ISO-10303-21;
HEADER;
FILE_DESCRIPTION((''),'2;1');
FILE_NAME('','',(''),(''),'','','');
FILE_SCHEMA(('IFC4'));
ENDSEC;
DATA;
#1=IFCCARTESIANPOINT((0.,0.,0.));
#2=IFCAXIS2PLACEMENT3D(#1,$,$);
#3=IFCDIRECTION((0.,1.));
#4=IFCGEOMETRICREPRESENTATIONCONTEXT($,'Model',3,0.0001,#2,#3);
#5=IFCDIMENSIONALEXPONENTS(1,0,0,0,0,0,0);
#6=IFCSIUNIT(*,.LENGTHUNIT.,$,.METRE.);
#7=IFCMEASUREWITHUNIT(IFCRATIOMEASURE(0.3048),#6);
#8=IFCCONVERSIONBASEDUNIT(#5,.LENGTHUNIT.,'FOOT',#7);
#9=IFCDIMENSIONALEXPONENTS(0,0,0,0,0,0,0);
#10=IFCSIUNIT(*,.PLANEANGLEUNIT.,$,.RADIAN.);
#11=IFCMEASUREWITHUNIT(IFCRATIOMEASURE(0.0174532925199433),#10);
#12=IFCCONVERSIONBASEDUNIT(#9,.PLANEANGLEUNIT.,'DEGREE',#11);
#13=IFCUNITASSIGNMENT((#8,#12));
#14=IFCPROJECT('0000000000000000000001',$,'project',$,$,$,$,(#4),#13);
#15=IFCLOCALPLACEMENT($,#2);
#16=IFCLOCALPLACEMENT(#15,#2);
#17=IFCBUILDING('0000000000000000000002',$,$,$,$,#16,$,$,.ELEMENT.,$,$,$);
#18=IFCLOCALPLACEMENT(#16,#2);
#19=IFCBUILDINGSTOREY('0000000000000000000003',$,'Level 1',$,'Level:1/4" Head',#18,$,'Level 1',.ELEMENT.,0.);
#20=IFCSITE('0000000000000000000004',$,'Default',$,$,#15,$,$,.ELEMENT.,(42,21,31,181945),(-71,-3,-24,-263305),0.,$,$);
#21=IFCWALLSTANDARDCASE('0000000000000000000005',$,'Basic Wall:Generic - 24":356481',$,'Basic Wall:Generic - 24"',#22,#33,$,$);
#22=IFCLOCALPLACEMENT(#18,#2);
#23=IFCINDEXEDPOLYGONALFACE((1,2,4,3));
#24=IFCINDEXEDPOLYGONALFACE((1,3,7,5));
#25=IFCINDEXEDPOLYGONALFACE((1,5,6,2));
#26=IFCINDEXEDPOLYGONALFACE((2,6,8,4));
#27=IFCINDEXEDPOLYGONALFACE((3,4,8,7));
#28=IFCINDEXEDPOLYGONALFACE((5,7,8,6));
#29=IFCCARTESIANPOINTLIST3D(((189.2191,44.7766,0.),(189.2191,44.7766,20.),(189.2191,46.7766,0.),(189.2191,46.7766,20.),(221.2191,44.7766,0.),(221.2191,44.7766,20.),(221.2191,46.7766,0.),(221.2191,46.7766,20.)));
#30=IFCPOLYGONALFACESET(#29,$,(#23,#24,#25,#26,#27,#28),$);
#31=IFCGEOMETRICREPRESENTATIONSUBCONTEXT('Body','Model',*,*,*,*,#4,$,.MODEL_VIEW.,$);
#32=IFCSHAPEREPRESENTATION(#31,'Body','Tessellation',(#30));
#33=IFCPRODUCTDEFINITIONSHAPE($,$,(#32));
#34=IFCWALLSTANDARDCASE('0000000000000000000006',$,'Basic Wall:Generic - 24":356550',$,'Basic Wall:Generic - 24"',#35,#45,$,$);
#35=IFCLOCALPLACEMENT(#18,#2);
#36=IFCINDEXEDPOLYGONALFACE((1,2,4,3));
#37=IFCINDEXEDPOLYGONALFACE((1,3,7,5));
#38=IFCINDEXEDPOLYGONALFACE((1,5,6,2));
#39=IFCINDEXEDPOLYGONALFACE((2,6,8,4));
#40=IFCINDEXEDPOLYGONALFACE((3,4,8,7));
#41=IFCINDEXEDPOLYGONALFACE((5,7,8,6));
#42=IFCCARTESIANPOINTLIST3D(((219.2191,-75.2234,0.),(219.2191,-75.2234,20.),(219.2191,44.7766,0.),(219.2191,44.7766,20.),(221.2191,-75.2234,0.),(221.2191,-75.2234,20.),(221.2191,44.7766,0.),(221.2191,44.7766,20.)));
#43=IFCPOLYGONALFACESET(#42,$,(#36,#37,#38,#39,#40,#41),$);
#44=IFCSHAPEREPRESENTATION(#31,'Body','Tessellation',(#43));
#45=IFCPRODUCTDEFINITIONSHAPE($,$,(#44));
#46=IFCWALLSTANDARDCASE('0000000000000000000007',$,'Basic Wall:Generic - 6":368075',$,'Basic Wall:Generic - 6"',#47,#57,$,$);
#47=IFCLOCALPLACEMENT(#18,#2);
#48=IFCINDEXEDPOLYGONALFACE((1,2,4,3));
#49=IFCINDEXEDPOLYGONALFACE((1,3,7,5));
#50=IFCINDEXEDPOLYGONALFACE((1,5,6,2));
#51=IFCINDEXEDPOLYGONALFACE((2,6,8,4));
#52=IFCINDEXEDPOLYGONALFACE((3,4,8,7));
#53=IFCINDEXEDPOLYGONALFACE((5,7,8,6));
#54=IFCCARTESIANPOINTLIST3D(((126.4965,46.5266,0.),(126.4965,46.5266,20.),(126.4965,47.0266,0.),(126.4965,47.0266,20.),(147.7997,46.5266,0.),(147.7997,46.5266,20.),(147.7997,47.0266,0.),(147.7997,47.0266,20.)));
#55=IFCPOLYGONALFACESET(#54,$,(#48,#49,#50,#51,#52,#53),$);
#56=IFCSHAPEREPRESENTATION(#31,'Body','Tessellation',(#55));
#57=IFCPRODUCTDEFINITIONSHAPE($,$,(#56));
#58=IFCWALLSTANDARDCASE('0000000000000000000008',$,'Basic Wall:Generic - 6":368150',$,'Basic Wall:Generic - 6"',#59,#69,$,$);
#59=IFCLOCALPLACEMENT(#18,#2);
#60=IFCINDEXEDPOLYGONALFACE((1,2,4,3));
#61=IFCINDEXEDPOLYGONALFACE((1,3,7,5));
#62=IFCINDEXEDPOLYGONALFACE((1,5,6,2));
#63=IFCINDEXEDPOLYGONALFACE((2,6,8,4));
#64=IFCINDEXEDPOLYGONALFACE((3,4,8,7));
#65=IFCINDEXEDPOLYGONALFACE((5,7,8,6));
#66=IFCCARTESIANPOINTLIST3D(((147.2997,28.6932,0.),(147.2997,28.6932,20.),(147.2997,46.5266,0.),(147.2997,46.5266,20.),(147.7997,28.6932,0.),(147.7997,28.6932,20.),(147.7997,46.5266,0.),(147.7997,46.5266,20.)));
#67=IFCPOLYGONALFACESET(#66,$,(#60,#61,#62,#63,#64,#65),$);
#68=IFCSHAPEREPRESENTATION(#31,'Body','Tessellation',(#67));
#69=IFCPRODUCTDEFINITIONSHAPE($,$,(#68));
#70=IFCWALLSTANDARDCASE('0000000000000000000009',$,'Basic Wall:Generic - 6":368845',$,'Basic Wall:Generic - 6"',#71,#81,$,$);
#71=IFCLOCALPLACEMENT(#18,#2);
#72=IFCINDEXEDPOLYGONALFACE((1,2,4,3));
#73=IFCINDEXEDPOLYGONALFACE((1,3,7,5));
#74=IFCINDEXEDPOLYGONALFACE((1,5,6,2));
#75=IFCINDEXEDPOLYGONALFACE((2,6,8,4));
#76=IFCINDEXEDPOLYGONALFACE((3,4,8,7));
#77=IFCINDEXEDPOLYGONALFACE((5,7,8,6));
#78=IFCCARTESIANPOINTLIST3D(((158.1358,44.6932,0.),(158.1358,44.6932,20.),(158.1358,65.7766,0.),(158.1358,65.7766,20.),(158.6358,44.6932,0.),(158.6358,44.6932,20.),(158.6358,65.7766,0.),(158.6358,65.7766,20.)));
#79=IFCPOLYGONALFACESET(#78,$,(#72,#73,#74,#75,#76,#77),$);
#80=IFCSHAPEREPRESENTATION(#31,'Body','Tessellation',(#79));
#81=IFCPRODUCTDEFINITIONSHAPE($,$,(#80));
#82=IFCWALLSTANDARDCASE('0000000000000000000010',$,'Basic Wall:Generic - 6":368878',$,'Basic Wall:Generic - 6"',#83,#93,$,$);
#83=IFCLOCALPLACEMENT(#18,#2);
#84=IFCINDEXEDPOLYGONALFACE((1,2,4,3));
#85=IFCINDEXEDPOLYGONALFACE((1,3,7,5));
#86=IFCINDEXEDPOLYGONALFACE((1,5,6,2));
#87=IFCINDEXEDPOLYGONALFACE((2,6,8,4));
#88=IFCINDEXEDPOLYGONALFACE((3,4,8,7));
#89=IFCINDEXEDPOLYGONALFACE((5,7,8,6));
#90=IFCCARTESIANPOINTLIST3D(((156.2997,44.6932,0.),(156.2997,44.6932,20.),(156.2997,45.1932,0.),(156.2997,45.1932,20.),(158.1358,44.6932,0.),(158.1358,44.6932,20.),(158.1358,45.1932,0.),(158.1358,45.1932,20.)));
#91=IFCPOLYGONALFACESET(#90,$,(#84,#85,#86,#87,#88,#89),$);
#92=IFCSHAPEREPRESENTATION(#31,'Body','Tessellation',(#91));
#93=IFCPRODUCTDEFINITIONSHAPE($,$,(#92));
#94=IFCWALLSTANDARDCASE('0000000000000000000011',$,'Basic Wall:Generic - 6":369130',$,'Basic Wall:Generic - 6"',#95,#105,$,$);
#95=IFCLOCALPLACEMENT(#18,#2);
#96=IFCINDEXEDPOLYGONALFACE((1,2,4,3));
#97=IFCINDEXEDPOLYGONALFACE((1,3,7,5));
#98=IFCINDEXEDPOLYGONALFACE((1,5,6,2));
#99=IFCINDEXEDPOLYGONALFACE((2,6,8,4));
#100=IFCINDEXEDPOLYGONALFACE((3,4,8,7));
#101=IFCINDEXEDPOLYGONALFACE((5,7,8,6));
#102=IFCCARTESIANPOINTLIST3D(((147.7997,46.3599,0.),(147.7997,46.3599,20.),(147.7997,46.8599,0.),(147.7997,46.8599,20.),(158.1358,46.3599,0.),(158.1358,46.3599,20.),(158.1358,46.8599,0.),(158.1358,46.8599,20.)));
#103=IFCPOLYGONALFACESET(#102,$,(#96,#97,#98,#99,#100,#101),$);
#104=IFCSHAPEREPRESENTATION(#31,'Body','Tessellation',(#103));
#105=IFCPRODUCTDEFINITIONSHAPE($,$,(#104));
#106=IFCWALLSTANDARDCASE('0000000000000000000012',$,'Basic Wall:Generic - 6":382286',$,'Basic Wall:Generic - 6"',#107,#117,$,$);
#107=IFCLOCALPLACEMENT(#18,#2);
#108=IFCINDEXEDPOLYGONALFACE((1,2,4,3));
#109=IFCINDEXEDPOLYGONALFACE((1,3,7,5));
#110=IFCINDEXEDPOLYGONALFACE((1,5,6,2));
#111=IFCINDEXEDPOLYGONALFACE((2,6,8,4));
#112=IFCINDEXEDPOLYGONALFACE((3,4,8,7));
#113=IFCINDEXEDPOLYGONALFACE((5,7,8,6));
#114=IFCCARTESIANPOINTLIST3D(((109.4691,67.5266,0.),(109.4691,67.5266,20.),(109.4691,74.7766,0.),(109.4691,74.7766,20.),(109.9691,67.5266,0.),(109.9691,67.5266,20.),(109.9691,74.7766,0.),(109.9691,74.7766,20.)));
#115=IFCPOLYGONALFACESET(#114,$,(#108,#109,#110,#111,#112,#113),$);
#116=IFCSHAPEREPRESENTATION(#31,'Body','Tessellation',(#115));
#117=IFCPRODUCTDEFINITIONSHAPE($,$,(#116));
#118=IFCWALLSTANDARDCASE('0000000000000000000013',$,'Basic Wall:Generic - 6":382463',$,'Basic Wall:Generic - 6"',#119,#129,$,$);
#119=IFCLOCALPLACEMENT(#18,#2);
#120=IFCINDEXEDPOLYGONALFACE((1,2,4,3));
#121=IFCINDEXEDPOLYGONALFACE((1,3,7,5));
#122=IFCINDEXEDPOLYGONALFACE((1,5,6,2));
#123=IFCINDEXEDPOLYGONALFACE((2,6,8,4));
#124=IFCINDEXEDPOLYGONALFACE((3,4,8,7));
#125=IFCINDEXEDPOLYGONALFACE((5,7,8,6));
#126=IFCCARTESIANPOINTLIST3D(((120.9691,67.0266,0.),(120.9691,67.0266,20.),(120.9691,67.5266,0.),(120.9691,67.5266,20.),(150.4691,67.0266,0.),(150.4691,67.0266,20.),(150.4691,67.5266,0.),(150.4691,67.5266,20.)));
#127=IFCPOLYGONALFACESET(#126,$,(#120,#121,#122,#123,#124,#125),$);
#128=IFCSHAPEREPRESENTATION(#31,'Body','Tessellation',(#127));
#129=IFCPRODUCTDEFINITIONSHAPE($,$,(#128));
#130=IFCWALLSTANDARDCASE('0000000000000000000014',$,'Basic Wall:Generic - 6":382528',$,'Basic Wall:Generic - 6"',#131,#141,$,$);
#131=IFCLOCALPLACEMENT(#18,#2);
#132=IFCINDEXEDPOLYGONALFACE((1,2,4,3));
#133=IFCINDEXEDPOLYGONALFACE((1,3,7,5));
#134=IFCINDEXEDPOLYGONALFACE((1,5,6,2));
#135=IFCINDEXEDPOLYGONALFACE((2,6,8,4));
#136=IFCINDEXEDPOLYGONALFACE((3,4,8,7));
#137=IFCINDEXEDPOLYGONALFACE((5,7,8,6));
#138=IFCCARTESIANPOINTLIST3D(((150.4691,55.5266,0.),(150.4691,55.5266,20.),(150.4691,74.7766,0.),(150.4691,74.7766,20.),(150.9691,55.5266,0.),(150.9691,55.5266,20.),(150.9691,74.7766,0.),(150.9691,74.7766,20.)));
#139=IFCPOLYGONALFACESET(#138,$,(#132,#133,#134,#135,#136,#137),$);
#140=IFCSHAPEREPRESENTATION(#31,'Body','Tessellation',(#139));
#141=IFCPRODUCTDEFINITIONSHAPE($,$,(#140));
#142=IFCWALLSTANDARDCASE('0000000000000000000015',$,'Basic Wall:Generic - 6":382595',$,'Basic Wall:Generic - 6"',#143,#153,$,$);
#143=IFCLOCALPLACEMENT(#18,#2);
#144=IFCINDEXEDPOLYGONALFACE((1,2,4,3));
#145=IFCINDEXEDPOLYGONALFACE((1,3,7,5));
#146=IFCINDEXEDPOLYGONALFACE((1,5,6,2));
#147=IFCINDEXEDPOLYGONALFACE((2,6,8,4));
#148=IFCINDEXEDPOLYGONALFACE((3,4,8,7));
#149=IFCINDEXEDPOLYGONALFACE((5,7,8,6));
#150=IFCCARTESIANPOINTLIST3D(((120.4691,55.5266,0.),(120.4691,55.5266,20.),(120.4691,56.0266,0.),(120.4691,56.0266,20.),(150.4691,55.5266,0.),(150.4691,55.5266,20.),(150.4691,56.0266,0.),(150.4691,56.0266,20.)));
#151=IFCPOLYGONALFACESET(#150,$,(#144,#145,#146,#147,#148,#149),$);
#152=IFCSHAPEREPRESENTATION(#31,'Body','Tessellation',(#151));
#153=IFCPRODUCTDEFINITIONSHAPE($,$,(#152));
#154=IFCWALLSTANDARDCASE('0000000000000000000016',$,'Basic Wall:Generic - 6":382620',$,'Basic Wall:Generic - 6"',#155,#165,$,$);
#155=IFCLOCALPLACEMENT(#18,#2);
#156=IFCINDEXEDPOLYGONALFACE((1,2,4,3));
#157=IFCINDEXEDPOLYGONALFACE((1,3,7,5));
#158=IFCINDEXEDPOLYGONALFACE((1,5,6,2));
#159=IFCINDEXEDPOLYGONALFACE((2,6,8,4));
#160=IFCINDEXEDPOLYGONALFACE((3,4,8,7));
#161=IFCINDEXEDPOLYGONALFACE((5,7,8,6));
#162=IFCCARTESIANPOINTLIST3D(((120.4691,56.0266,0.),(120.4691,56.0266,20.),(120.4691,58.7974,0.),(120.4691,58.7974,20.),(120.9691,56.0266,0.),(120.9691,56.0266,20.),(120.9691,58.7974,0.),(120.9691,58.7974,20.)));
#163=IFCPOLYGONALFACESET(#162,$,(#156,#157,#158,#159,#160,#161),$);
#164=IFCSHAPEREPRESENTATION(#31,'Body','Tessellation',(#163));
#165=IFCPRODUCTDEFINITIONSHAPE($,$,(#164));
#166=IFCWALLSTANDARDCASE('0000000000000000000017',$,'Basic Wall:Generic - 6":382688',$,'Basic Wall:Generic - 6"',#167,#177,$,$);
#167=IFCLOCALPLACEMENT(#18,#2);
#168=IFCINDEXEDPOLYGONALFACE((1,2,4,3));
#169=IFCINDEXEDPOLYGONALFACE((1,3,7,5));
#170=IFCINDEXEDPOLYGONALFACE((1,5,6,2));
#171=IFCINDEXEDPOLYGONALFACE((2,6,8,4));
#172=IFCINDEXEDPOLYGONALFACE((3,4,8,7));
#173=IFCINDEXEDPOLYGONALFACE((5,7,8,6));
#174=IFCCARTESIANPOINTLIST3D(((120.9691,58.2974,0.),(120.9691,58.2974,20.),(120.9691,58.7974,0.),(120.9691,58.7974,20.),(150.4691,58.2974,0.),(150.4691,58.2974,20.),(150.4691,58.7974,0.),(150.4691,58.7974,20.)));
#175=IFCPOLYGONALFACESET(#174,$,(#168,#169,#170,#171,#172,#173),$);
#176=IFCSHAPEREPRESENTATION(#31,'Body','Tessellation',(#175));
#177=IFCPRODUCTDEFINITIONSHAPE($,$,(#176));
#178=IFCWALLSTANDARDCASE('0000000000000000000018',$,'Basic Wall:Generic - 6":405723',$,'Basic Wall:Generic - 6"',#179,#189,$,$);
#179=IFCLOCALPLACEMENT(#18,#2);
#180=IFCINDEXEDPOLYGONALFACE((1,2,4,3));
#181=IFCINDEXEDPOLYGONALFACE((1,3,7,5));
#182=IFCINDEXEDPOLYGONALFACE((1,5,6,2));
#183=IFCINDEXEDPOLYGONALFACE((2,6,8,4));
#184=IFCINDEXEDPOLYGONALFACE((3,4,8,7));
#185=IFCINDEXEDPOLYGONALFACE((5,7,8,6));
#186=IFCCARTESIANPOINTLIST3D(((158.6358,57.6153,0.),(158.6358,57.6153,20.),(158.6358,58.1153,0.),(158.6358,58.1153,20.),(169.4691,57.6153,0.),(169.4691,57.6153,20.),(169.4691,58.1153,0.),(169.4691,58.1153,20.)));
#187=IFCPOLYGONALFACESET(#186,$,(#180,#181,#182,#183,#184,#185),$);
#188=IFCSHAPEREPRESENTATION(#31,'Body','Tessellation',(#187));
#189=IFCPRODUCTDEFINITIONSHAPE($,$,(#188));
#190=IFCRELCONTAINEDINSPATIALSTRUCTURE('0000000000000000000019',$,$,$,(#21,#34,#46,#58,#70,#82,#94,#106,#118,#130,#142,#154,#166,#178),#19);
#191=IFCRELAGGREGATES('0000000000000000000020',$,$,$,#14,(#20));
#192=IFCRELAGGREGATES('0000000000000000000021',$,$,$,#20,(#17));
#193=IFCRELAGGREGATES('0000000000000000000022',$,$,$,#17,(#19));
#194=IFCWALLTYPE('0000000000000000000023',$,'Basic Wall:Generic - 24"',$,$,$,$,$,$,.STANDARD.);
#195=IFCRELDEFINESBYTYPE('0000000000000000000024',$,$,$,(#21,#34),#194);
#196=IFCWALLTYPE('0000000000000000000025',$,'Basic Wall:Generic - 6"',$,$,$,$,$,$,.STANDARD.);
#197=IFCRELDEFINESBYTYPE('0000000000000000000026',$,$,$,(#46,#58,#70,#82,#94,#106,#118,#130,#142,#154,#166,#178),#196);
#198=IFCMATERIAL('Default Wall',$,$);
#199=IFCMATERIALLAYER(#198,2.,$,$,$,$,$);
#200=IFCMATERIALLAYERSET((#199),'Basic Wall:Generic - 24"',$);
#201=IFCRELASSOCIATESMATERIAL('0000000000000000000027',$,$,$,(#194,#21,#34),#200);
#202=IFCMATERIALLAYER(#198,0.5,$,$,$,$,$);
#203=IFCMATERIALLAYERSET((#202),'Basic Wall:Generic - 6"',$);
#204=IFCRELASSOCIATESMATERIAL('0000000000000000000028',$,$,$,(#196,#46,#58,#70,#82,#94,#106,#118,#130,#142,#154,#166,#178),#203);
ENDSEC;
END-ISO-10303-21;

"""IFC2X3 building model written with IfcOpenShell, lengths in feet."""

from ifc_helpers import new_model, entity, si_unit, converted_unit, direction, frame, frame_2d, origin, place, context, subcontext, project, spatial, rectangle, extrude, material, layer, layer_set, layer_usage, type_object, element, save


model = new_model("IFC2X3")

# Units and contexts
model_context = context("Model", 3, precision=0.0001, world=origin(), true_north=direction((0.0, 1.0)))
body_context = subcontext(model_context, "Body", "Model", "MODEL_VIEW")
ifc_project = project(units=[converted_unit("LENGTHUNIT", "FOOT", entity("IfcRatioMeasure", 0.3048), si_unit("LENGTHUNIT", "METRE"), dimensions=[1, 0, 0, 0, 0, 0, 0]), converted_unit("PLANEANGLEUNIT", "DEGREE", entity("IfcRatioMeasure", 0.0174532925199433), si_unit("PLANEANGLEUNIT", "RADIAN"), dimensions=[0, 0, 0, 0, 0, 0, 0])], contexts=[model_context])

# Site, building, storey
site_placement = place(None, origin())
site = spatial("IfcSite", under=ifc_project, at=site_placement, Name="Default", CompositionType="ELEMENT", RefLatitude=(42, 21, 31, 181945), RefLongitude=(-71, -3, -24, -263305), RefElevation=0.0)
building_placement = place(site_placement, origin())
building = spatial("IfcBuilding", under=site, at=building_placement, CompositionType="ELEMENT")
storey_placement = place(building_placement, origin())
storey = spatial("IfcBuildingStorey", under=building, at=storey_placement, Name="Level 1", ObjectType="Level:1/4\" Head", LongName="Level 1", CompositionType="ELEMENT", Elevation=0.0)

# Walls
ifc_material = material(Name="Default Wall")
ifc_layer_1 = layer(ifc_material, 2.0)
ifc_layer_set_1 = layer_set([ifc_layer_1], Name="Basic Wall:Generic - 24\"")
ifc_layer_usage_1 = layer_usage(ifc_layer_set_1, "AXIS2", "NEGATIVE", 1.0)
wall_type_1 = type_object("IfcWallType", Name="Basic Wall:Generic - 24\"", PredefinedType="STANDARD", material=ifc_layer_set_1)
wall_1_placement = place(storey_placement, frame((189.2191, 45.7766, 0.0)))
element("IfcWallStandardCase", 1, at=wall_1_placement, inside=storey, type_object=wall_type_1, material=ifc_layer_usage_1, Name="Basic Wall:Generic - 24\":356481", ObjectType="Basic Wall:Generic - 24\"", context=body_context, shape_type="SweptSolid", body=[
    extrude(rectangle(XDim=32.0, YDim=2.0, at=frame_2d((16.0, 0.0), x_axis=(-1.0, 0.0))), origin(), (0.0, 0.0, 1.0), 20.0),
])
ifc_layer_usage_2 = layer_usage(ifc_layer_set_1, "AXIS2", "NEGATIVE", 1.0)
wall_2_placement = place(storey_placement, frame((220.2191, 44.7766, 0.0), z_axis=(0.0, 0.0, 1.0), x_axis=(0.0, -1.0, 0.0)))
element("IfcWallStandardCase", 2, at=wall_2_placement, inside=storey, type_object=wall_type_1, material=ifc_layer_usage_2, Name="Basic Wall:Generic - 24\":356550", ObjectType="Basic Wall:Generic - 24\"", context=body_context, shape_type="SweptSolid", body=[
    extrude(rectangle(XDim=120.0, YDim=2.0, at=frame_2d((60.0, 0.0), x_axis=(-1.0, 0.0))), origin(), (0.0, 0.0, 1.0), 20.0),
])
ifc_layer_2 = layer(ifc_material, 0.5)
ifc_layer_set_2 = layer_set([ifc_layer_2], Name="Basic Wall:Generic - 6\"")
ifc_layer_usage_3 = layer_usage(ifc_layer_set_2, "AXIS2", "NEGATIVE", 0.25)
wall_type_2 = type_object("IfcWallType", Name="Basic Wall:Generic - 6\"", PredefinedType="STANDARD", material=ifc_layer_set_2)
wall_3_placement = place(storey_placement, frame((126.4965, 46.7766, 0.0)))
element("IfcWallStandardCase", 3, at=wall_3_placement, inside=storey, type_object=wall_type_2, material=ifc_layer_usage_3, Name="Basic Wall:Generic - 6\":368075", ObjectType="Basic Wall:Generic - 6\"", context=body_context, shape_type="SweptSolid", body=[
    extrude(rectangle(XDim=21.3031, YDim=0.5, at=frame_2d((10.6516, 0.0), x_axis=(-1.0, 0.0))), origin(), (0.0, 0.0, 1.0), 20.0),
])
ifc_layer_usage_4 = layer_usage(ifc_layer_set_2, "AXIS2", "NEGATIVE", 0.25)
wall_4_placement = place(storey_placement, frame((147.5497, 46.5266, 0.0), z_axis=(0.0, 0.0, 1.0), x_axis=(0.0, -1.0, 0.0)))
element("IfcWallStandardCase", 4, at=wall_4_placement, inside=storey, type_object=wall_type_2, material=ifc_layer_usage_4, Name="Basic Wall:Generic - 6\":368150", ObjectType="Basic Wall:Generic - 6\"", context=body_context, shape_type="SweptSolid", body=[
    extrude(rectangle(XDim=17.8333, YDim=0.5, at=frame_2d((8.9167, 0.0), x_axis=(-1.0, 0.0))), origin(), (0.0, 0.0, 1.0), 20.0),
])
ifc_layer_usage_5 = layer_usage(ifc_layer_set_2, "AXIS2", "NEGATIVE", 0.25)
wall_5_placement = place(storey_placement, frame((158.3858, 65.7766, 0.0), z_axis=(0.0, 0.0, 1.0), x_axis=(0.0, -1.0, 0.0)))
element("IfcWallStandardCase", 5, at=wall_5_placement, inside=storey, type_object=wall_type_2, material=ifc_layer_usage_5, Name="Basic Wall:Generic - 6\":368845", ObjectType="Basic Wall:Generic - 6\"", context=body_context, shape_type="SweptSolid", body=[
    extrude(rectangle(XDim=21.0833, YDim=0.5, at=frame_2d((10.5417, 0.0), x_axis=(-1.0, 0.0))), origin(), (0.0, 0.0, 1.0), 20.0),
])
ifc_layer_usage_6 = layer_usage(ifc_layer_set_2, "AXIS2", "NEGATIVE", 0.25)
wall_6_placement = place(storey_placement, frame((158.1358, 44.9432, 0.0), z_axis=(0.0, 0.0, 1.0), x_axis=(-1.0, 0.0, 0.0)))
element("IfcWallStandardCase", 6, at=wall_6_placement, inside=storey, type_object=wall_type_2, material=ifc_layer_usage_6, Name="Basic Wall:Generic - 6\":368878", ObjectType="Basic Wall:Generic - 6\"", context=body_context, shape_type="SweptSolid", body=[
    extrude(rectangle(XDim=1.8361, YDim=0.5, at=frame_2d((0.9181, 0.0), x_axis=(-1.0, 0.0))), origin(), (0.0, 0.0, 1.0), 20.0),
])
ifc_layer_usage_7 = layer_usage(ifc_layer_set_2, "AXIS2", "NEGATIVE", 0.25)
wall_7_placement = place(storey_placement, frame((158.1358, 46.6099, 0.0), z_axis=(0.0, 0.0, 1.0), x_axis=(-1.0, 0.0, 0.0)))
element("IfcWallStandardCase", 7, at=wall_7_placement, inside=storey, type_object=wall_type_2, material=ifc_layer_usage_7, Name="Basic Wall:Generic - 6\":369130", ObjectType="Basic Wall:Generic - 6\"", context=body_context, shape_type="SweptSolid", body=[
    extrude(rectangle(XDim=10.3361, YDim=0.5, at=frame_2d((5.1681, 0.0), x_axis=(-1.0, 0.0))), origin(), (0.0, 0.0, 1.0), 20.0),
])
ifc_layer_usage_8 = layer_usage(ifc_layer_set_2, "AXIS2", "NEGATIVE", 0.25)
wall_8_placement = place(storey_placement, frame((109.7191, 67.5266, 0.0), z_axis=(0.0, 0.0, 1.0), x_axis=(0.0, 1.0, 0.0)))
element("IfcWallStandardCase", 8, at=wall_8_placement, inside=storey, type_object=wall_type_2, material=ifc_layer_usage_8, Name="Basic Wall:Generic - 6\":382286", ObjectType="Basic Wall:Generic - 6\"", context=body_context, shape_type="SweptSolid", body=[
    extrude(rectangle(XDim=7.25, YDim=0.5, at=frame_2d((3.625, 0.0), x_axis=(-1.0, 0.0))), origin(), (0.0, 0.0, 1.0), 20.0),
])
ifc_layer_usage_9 = layer_usage(ifc_layer_set_2, "AXIS2", "NEGATIVE", 0.25)
wall_9_placement = place(storey_placement, frame((120.9691, 67.2766, 0.0)))
element("IfcWallStandardCase", 9, at=wall_9_placement, inside=storey, type_object=wall_type_2, material=ifc_layer_usage_9, Name="Basic Wall:Generic - 6\":382463", ObjectType="Basic Wall:Generic - 6\"", context=body_context, shape_type="SweptSolid", body=[
    extrude(rectangle(XDim=29.5, YDim=0.5, at=frame_2d((14.75, 0.0), x_axis=(-1.0, 0.0))), origin(), (0.0, 0.0, 1.0), 20.0),
])
ifc_layer_usage_10 = layer_usage(ifc_layer_set_2, "AXIS2", "NEGATIVE", 0.25)
wall_10_placement = place(storey_placement, frame((150.7191, 74.7766, 0.0), z_axis=(0.0, 0.0, 1.0), x_axis=(0.0, -1.0, 0.0)))
element("IfcWallStandardCase", 10, at=wall_10_placement, inside=storey, type_object=wall_type_2, material=ifc_layer_usage_10, Name="Basic Wall:Generic - 6\":382528", ObjectType="Basic Wall:Generic - 6\"", context=body_context, shape_type="SweptSolid", body=[
    extrude(rectangle(XDim=19.25, YDim=0.5, at=frame_2d((9.625, 0.0), x_axis=(-1.0, 0.0))), origin(), (0.0, 0.0, 1.0), 20.0),
])
ifc_layer_usage_11 = layer_usage(ifc_layer_set_2, "AXIS2", "NEGATIVE", 0.25)
wall_11_placement = place(storey_placement, frame((150.4691, 55.7766, 0.0), z_axis=(0.0, 0.0, 1.0), x_axis=(-1.0, 0.0, 0.0)))
element("IfcWallStandardCase", 11, at=wall_11_placement, inside=storey, type_object=wall_type_2, material=ifc_layer_usage_11, Name="Basic Wall:Generic - 6\":382595", ObjectType="Basic Wall:Generic - 6\"", context=body_context, shape_type="SweptSolid", body=[
    extrude(rectangle(XDim=30.0, YDim=0.5, at=frame_2d((15.0, 0.0), x_axis=(-1.0, 0.0))), origin(), (0.0, 0.0, 1.0), 20.0),
])
ifc_layer_usage_12 = layer_usage(ifc_layer_set_2, "AXIS2", "NEGATIVE", 0.25)
wall_12_placement = place(storey_placement, frame((120.7191, 56.0266, 0.0), z_axis=(0.0, 0.0, 1.0), x_axis=(0.0, 1.0, 0.0)))
element("IfcWallStandardCase", 12, at=wall_12_placement, inside=storey, type_object=wall_type_2, material=ifc_layer_usage_12, Name="Basic Wall:Generic - 6\":382620", ObjectType="Basic Wall:Generic - 6\"", context=body_context, shape_type="SweptSolid", body=[
    extrude(rectangle(XDim=2.7708, YDim=0.5, at=frame_2d((1.3854, 0.0), x_axis=(-1.0, 0.0))), origin(), (0.0, 0.0, 1.0), 20.0),
])
ifc_layer_usage_13 = layer_usage(ifc_layer_set_2, "AXIS2", "NEGATIVE", 0.25)
wall_13_placement = place(storey_placement, frame((120.9691, 58.5474, 0.0)))
element("IfcWallStandardCase", 13, at=wall_13_placement, inside=storey, type_object=wall_type_2, material=ifc_layer_usage_13, Name="Basic Wall:Generic - 6\":382688", ObjectType="Basic Wall:Generic - 6\"", context=body_context, shape_type="SweptSolid", body=[
    extrude(rectangle(XDim=29.5, YDim=0.5, at=frame_2d((14.75, 0.0), x_axis=(-1.0, 0.0))), origin(), (0.0, 0.0, 1.0), 20.0),
])
ifc_layer_usage_14 = layer_usage(ifc_layer_set_2, "AXIS2", "NEGATIVE", 0.25)
wall_14_placement = place(storey_placement, frame((158.6358, 57.8653, 0.0)))
element("IfcWallStandardCase", 14, at=wall_14_placement, inside=storey, type_object=wall_type_2, material=ifc_layer_usage_14, Name="Basic Wall:Generic - 6\":405723", ObjectType="Basic Wall:Generic - 6\"", context=body_context, shape_type="SweptSolid", body=[
    extrude(rectangle(XDim=10.8333, YDim=0.5, at=frame_2d((5.4167, 0.0), x_axis=(-1.0, 0.0))), origin(), (0.0, 0.0, 1.0), 20.0),
])

save(model, "model.ifc")
